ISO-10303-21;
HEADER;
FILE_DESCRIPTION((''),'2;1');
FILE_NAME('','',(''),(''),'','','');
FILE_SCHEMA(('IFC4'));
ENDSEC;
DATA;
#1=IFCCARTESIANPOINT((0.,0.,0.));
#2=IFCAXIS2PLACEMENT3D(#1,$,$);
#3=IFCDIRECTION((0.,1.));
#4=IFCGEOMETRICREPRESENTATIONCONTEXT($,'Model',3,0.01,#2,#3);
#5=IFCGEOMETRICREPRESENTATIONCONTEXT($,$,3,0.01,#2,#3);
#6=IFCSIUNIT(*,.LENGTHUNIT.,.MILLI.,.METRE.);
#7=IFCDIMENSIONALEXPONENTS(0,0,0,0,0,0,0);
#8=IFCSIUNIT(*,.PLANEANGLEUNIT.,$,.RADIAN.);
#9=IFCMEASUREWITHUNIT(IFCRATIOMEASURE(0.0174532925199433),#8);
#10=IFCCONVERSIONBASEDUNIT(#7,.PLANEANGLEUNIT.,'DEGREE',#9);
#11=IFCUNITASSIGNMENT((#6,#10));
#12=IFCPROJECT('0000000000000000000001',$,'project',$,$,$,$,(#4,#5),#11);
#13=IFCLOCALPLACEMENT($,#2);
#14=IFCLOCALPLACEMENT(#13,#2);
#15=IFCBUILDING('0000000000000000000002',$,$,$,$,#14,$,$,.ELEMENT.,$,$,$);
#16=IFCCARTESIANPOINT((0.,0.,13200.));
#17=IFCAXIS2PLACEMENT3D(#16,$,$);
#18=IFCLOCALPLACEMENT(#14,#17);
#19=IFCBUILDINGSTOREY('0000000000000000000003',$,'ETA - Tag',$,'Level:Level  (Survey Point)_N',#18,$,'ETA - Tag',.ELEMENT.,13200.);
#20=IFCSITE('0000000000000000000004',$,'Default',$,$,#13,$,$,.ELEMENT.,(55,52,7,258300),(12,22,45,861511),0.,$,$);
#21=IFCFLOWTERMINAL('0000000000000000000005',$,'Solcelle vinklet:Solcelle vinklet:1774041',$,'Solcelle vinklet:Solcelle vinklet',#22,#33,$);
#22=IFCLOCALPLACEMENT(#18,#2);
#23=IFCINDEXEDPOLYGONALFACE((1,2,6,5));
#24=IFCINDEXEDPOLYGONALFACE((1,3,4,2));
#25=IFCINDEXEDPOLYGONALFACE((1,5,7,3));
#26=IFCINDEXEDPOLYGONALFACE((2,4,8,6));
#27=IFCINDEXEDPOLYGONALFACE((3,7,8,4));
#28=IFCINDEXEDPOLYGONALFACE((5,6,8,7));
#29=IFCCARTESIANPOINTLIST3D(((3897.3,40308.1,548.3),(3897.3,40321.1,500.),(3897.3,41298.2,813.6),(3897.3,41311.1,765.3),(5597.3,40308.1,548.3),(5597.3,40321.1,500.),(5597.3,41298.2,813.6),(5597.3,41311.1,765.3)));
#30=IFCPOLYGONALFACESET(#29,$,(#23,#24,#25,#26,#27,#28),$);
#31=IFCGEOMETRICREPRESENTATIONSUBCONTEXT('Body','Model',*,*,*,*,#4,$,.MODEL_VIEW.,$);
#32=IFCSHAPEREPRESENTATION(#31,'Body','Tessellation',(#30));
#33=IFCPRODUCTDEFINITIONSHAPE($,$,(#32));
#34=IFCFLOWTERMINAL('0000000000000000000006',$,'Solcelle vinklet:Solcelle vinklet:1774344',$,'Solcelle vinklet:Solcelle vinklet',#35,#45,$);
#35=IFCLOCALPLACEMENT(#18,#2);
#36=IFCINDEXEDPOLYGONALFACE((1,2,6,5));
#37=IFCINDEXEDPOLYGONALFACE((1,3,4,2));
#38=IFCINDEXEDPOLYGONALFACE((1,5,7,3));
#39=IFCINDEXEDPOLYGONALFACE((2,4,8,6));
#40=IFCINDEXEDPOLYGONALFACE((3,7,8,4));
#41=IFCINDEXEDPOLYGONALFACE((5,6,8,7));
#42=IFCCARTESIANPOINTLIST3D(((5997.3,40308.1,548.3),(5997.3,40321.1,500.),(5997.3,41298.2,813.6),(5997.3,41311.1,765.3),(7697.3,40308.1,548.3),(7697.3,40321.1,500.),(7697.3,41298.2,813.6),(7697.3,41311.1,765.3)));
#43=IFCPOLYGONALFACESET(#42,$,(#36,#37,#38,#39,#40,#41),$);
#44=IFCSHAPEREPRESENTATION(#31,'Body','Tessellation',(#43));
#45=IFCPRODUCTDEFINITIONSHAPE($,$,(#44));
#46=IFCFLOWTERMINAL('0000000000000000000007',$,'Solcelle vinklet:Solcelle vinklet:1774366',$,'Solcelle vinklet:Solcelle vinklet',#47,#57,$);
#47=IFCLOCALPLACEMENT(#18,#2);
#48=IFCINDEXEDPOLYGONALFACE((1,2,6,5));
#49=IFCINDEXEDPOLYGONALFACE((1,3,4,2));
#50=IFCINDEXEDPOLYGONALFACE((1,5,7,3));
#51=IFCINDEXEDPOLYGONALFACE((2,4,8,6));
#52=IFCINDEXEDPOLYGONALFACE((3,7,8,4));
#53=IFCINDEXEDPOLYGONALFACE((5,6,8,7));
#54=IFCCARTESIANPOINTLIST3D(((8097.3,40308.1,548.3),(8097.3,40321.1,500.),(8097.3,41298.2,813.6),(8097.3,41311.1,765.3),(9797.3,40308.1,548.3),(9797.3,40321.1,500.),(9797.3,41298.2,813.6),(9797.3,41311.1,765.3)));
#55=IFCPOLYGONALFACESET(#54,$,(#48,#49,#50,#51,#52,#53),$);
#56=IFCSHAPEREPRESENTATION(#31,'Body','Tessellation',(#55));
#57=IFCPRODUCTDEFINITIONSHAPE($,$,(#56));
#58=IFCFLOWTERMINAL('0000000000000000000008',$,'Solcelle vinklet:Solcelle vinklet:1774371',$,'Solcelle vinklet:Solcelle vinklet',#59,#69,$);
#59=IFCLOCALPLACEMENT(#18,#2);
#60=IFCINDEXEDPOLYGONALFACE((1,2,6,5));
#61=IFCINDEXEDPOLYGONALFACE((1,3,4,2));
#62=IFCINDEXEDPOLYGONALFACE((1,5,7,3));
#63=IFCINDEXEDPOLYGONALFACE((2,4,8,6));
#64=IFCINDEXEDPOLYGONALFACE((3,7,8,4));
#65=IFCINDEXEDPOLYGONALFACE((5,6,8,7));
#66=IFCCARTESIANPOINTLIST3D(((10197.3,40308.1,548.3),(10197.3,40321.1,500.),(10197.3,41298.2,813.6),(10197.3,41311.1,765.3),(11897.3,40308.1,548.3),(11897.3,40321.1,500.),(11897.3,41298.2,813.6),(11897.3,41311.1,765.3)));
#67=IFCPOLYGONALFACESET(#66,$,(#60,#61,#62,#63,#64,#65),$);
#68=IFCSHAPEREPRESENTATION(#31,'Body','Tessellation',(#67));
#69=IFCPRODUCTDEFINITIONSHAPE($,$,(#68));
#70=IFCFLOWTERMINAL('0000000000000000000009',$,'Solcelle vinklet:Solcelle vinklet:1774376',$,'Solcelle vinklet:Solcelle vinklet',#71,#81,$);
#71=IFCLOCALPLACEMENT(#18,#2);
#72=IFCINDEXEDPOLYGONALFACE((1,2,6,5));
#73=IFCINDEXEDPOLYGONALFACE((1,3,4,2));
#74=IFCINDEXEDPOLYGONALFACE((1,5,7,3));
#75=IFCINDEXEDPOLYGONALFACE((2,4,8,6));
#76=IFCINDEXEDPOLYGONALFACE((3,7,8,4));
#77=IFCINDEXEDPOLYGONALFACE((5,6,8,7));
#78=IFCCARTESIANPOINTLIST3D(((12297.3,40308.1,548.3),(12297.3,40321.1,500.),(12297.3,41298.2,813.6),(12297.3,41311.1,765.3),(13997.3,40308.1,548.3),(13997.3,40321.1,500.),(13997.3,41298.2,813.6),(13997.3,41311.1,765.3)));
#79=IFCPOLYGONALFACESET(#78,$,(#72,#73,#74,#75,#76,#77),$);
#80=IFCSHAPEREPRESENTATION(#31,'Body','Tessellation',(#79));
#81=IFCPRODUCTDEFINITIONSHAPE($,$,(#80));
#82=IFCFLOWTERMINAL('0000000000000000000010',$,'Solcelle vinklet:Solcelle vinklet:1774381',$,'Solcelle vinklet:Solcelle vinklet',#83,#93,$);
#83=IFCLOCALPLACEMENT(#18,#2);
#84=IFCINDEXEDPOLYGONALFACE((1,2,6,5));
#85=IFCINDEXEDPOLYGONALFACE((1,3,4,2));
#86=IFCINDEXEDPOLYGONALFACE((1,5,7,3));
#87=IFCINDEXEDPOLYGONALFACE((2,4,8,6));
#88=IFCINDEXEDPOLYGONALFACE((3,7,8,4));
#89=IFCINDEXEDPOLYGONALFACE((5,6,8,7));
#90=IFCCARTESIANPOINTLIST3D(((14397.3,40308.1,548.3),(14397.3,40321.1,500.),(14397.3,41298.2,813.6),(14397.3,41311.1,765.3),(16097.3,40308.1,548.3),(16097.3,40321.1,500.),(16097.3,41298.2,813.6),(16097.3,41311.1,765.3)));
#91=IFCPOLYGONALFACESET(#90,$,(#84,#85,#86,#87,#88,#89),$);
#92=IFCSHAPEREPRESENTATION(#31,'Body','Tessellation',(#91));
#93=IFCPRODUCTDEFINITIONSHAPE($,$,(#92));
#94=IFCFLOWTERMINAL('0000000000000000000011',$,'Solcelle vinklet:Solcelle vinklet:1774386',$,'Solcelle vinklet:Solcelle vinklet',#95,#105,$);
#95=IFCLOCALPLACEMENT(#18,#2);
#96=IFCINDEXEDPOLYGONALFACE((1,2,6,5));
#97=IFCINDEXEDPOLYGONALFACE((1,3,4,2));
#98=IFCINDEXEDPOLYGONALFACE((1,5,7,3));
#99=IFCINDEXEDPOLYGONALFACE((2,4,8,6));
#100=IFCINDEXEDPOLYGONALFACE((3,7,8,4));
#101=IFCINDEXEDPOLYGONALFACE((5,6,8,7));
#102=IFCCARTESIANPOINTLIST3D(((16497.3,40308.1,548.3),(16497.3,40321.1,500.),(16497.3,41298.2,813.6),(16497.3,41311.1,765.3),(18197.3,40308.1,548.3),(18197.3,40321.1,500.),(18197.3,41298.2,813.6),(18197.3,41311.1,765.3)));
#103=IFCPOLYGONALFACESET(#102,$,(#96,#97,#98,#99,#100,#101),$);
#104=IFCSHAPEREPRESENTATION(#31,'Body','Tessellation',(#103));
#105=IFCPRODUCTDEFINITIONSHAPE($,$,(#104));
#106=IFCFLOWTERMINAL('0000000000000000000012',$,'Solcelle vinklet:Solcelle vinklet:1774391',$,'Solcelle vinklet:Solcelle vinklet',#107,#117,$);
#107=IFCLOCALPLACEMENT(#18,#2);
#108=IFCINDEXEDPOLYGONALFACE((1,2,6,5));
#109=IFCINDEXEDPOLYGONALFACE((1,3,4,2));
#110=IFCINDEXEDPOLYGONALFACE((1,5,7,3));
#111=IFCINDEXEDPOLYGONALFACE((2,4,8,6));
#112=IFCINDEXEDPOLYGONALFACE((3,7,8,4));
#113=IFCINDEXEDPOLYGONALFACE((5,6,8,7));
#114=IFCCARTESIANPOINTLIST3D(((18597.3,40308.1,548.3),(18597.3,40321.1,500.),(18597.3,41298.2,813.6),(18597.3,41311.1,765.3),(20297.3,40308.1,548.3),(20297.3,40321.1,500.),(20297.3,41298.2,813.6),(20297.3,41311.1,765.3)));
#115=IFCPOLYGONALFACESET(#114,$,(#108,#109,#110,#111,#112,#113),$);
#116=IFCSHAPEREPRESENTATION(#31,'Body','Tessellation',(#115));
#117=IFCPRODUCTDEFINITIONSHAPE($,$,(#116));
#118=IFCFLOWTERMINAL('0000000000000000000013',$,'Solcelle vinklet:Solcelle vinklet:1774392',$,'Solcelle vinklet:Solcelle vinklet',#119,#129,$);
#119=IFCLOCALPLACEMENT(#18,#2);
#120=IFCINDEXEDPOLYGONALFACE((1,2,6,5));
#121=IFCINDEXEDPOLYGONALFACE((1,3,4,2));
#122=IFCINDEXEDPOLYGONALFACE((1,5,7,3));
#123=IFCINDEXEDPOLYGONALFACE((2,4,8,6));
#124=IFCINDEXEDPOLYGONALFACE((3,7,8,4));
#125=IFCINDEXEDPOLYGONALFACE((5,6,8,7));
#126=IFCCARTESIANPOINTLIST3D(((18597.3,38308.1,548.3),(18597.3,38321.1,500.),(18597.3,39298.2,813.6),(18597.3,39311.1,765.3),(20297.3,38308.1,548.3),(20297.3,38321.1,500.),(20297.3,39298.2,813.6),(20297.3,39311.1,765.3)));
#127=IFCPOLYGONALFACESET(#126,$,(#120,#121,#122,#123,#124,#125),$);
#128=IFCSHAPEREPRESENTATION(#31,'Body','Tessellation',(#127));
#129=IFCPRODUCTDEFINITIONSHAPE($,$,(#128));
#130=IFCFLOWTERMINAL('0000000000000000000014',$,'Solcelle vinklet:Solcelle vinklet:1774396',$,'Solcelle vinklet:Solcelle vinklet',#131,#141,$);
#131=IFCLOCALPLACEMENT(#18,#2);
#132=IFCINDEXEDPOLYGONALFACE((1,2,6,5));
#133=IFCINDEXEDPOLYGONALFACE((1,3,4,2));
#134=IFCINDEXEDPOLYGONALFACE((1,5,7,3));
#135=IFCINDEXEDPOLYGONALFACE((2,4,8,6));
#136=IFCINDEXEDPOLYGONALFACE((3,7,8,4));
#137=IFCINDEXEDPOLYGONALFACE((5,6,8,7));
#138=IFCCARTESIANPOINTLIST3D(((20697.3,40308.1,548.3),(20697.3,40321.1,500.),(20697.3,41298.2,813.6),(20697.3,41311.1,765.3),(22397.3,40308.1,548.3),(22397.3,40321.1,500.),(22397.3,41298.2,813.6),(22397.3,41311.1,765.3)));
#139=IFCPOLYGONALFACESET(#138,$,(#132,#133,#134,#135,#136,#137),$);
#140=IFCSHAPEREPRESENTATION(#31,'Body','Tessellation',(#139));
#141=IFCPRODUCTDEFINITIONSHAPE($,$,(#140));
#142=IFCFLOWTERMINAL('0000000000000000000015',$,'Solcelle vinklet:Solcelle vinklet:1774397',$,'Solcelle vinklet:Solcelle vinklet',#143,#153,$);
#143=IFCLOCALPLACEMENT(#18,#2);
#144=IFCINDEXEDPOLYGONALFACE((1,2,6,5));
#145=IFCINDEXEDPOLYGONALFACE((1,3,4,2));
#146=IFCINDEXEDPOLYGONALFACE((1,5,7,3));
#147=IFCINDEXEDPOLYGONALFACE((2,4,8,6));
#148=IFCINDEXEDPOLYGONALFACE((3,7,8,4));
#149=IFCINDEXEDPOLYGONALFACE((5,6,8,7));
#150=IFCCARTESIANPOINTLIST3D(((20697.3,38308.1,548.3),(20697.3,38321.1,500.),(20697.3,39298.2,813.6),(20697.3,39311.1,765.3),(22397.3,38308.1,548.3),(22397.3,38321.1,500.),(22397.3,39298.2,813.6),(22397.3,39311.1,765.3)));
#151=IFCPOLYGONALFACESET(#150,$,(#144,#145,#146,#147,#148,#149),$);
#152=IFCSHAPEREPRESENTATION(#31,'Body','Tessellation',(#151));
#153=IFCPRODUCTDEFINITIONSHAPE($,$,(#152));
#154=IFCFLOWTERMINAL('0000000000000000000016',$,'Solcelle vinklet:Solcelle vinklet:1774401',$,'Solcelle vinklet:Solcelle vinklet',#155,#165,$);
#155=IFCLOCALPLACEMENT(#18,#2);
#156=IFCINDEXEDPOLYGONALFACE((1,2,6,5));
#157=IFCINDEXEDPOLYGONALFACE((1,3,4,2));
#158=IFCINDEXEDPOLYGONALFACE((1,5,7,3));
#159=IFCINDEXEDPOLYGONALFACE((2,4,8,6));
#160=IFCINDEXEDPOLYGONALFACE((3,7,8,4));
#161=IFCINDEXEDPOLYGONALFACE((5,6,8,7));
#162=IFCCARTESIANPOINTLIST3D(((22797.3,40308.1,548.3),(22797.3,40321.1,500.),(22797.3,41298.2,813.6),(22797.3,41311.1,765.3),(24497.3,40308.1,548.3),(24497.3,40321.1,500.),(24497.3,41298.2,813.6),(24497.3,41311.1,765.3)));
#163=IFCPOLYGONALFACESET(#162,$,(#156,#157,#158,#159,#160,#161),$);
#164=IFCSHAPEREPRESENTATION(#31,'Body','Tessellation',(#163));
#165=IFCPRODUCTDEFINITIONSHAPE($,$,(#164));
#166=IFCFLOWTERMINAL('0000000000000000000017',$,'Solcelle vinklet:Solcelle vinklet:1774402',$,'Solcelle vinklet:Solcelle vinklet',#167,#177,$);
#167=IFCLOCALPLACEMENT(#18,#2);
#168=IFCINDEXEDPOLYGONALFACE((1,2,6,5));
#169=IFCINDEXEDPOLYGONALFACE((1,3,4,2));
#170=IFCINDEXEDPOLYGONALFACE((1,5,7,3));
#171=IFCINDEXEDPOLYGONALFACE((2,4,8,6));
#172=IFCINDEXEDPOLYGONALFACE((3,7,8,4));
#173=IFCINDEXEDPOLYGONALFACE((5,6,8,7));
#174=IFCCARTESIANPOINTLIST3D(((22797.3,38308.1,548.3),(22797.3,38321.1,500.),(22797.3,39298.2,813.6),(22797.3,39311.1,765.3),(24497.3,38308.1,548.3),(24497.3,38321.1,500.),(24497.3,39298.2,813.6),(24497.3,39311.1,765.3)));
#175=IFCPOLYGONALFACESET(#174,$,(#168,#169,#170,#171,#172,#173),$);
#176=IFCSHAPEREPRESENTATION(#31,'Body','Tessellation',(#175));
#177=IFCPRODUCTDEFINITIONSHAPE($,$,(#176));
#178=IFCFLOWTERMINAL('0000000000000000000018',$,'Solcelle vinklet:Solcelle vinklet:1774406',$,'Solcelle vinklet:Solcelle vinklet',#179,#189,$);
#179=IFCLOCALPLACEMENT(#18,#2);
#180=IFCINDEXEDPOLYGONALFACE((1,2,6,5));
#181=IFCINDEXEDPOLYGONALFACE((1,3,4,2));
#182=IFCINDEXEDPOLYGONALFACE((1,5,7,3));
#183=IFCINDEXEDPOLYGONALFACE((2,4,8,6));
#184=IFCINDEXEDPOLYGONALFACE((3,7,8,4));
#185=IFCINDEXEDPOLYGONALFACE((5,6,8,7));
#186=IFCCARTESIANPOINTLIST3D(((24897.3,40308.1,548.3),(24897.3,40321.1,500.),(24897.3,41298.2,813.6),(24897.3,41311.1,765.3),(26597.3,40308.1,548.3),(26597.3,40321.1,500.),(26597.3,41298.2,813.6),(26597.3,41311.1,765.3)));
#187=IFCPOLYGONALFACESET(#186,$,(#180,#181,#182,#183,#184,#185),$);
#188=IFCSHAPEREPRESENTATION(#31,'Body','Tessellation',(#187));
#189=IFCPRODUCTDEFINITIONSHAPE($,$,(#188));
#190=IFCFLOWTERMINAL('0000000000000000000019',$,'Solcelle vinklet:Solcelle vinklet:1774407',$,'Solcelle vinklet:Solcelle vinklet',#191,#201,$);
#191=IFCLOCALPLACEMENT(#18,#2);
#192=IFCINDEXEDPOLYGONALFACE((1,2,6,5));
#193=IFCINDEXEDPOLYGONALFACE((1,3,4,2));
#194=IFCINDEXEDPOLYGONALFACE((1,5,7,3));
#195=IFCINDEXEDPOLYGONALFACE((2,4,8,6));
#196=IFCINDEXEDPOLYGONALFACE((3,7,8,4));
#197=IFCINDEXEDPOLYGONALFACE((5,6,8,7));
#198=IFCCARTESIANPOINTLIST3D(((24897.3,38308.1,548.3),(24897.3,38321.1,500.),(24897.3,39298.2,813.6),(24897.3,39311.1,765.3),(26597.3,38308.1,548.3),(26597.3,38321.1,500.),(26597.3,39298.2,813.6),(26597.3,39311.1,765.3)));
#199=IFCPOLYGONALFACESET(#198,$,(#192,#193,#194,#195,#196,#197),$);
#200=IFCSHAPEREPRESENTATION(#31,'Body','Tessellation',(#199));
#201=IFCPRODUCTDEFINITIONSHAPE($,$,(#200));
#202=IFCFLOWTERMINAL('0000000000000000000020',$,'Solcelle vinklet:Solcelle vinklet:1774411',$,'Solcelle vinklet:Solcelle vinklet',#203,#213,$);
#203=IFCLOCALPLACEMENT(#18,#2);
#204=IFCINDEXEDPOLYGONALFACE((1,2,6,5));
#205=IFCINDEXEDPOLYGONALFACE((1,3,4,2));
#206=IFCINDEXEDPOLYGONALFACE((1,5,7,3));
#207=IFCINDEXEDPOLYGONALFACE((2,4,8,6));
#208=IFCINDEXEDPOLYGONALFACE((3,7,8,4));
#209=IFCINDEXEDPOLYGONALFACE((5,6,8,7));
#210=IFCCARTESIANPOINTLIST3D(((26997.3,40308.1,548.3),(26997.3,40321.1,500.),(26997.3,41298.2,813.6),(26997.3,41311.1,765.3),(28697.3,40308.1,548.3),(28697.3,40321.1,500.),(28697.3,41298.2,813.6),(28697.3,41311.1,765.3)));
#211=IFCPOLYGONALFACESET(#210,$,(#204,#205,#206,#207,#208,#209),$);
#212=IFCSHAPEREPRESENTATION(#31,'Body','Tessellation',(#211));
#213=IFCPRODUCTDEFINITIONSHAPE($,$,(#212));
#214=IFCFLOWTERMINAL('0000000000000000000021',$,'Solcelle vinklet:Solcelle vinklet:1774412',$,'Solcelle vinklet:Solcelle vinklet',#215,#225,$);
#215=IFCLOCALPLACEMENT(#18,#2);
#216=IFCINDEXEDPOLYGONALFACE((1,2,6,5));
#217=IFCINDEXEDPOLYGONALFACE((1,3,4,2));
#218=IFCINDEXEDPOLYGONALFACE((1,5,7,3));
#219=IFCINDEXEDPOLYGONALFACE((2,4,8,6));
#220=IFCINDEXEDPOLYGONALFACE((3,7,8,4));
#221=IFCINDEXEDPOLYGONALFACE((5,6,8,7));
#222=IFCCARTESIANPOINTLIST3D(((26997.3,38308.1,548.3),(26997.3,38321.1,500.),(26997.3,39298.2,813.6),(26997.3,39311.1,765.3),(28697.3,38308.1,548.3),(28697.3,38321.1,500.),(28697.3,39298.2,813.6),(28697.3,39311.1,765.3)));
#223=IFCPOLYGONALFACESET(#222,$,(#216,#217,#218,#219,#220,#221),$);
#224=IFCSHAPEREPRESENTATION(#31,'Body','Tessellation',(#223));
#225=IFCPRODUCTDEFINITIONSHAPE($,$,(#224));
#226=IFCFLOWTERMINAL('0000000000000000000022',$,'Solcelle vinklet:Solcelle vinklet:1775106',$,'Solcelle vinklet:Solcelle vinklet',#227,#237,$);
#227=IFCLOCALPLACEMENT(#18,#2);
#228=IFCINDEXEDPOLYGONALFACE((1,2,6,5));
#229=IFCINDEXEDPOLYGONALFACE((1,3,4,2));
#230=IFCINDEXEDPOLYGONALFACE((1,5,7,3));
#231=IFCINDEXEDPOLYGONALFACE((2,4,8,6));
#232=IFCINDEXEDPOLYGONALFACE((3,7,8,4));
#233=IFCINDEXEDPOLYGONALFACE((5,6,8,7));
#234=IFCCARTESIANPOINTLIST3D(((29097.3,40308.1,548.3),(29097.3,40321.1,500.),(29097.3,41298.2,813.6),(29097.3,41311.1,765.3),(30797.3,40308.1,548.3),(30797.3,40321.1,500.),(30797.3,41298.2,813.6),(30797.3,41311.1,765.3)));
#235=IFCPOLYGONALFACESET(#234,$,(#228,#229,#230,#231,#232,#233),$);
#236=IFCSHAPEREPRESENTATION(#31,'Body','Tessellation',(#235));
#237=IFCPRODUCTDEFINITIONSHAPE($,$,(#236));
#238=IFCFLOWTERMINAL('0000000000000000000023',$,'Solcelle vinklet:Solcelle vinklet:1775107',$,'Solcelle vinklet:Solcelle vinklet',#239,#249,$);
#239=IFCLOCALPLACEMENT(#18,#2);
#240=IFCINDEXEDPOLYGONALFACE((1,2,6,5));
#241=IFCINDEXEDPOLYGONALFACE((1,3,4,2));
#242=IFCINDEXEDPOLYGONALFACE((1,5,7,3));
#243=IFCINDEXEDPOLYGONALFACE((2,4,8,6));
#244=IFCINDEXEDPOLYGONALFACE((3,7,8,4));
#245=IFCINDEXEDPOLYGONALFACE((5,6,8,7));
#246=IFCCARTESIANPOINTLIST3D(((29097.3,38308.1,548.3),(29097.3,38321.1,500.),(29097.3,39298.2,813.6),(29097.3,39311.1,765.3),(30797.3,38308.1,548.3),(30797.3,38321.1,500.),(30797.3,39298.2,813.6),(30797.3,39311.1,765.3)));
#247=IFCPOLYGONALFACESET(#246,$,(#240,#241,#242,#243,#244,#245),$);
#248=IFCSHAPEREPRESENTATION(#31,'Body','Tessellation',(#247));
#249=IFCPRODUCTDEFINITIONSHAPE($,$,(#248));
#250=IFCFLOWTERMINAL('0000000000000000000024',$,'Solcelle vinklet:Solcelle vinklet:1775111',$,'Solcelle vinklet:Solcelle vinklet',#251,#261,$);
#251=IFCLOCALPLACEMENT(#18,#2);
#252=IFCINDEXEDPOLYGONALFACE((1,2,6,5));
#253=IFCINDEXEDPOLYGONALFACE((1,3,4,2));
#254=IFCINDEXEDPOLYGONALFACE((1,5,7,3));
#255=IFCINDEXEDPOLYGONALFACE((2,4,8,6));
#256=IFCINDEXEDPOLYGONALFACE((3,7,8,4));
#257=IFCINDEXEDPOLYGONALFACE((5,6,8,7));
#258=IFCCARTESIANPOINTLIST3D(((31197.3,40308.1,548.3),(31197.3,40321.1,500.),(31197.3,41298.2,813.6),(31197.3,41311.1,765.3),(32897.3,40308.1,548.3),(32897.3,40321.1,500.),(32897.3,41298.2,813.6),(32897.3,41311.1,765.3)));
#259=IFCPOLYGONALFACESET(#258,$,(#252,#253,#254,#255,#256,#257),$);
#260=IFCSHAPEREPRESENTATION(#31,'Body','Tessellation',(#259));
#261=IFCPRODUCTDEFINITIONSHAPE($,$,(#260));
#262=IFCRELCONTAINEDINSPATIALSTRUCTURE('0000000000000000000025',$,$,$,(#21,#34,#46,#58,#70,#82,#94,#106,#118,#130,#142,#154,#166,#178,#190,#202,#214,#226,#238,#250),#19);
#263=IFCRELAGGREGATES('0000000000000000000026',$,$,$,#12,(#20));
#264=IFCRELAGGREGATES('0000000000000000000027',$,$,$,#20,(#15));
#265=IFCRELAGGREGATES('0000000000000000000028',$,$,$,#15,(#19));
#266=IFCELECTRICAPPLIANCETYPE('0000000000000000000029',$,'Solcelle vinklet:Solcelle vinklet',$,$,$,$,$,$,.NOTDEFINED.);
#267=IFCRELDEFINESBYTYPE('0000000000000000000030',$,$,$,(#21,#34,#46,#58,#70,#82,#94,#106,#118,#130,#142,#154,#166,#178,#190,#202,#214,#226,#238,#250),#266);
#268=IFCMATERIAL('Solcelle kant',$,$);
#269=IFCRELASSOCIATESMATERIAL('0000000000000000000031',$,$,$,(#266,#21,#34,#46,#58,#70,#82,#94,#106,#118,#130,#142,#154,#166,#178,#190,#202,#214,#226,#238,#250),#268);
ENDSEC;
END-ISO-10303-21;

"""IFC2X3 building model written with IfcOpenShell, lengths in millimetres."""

from ifc_helpers import new_model, entity, si_unit, converted_unit, direction, frame, frame_2d, origin, place, context, subcontext, project, spatial, rectangle, extrude, source, transform, mapped, material, type_object, type_shapes, element, save


model = new_model("IFC2X3")

# Units and contexts
model_context = context("Model", 3, precision=0.01, world=origin(), true_north=direction((0.0, 1.0)))
context_of_model = context(None, 3, precision=0.01, world=origin(), true_north=direction((0.0, 1.0)))
body_context = subcontext(model_context, "Body", "Model", "MODEL_VIEW")
ifc_project = project(units=[si_unit("LENGTHUNIT", "METRE", prefix="MILLI"), converted_unit("PLANEANGLEUNIT", "DEGREE", entity("IfcRatioMeasure", 0.0174532925199433), si_unit("PLANEANGLEUNIT", "RADIAN"), dimensions=[0, 0, 0, 0, 0, 0, 0])], contexts=[model_context, context_of_model])

# Site, building, storey
site_placement = place(None, origin())
site = spatial("IfcSite", under=ifc_project, at=site_placement, Name="Default", CompositionType="ELEMENT", RefLatitude=(55, 52, 7, 258300), RefLongitude=(12, 22, 45, 861511), RefElevation=0.0)
building_placement = place(site_placement, origin())
building = spatial("IfcBuilding", under=site, at=building_placement, CompositionType="ELEMENT")
storey_placement = place(building_placement, frame((0.0, 0.0, 13200.0)))
storey = spatial("IfcBuildingStorey", under=building, at=storey_placement, Name="ETA - Tag", ObjectType="Level:Level  (Survey Point)_N", LongName="ETA - Tag", CompositionType="ELEMENT", Elevation=13200.0)

# Flow terminals
ifc_material = material(Name="Solcelle kant")
electric_appliance_type = type_object("IfcElectricApplianceType", Name="Solcelle vinklet:Solcelle vinklet", PredefinedType="NOTDEFINED", material=ifc_material)
shared_shape = source(origin(), body_context, "Body", "SweptSolid", [
    extrude(rectangle(XDim=50.0, YDim=1025.0, at=frame_2d((0.0, 0.0), x_axis=(1.0, 0.0))), frame((-850.0, 488.6, 156.8), z_axis=(1.0, 0.0, 0.0), x_axis=(0.0, 0.258819, -0.965926)), (0.0, 0.0, 1.0), 1700.0),
])
type_shapes(electric_appliance_type, [shared_shape])
for number, where, name in (
    (1, (4747.3, 40321.1, 500.0), "Solcelle vinklet:Solcelle vinklet:1774041"),
    (2, (6847.3, 40321.1, 500.0), "Solcelle vinklet:Solcelle vinklet:1774344"),
    (3, (8947.3, 40321.1, 500.0), "Solcelle vinklet:Solcelle vinklet:1774366"),
    (4, (11047.3, 40321.1, 500.0), "Solcelle vinklet:Solcelle vinklet:1774371"),
    (5, (13147.3, 40321.1, 500.0), "Solcelle vinklet:Solcelle vinklet:1774376"),
    (6, (15247.3, 40321.1, 500.0), "Solcelle vinklet:Solcelle vinklet:1774381"),
    (7, (17347.3, 40321.1, 500.0), "Solcelle vinklet:Solcelle vinklet:1774386"),
    (8, (19447.3, 40321.1, 500.0), "Solcelle vinklet:Solcelle vinklet:1774391"),
    (9, (19447.3, 38321.1, 500.0), "Solcelle vinklet:Solcelle vinklet:1774392"),
    (10, (21547.3, 40321.1, 500.0), "Solcelle vinklet:Solcelle vinklet:1774396"),
    (11, (21547.3, 38321.1, 500.0), "Solcelle vinklet:Solcelle vinklet:1774397"),
    (12, (23647.3, 40321.1, 500.0), "Solcelle vinklet:Solcelle vinklet:1774401"),
    (13, (23647.3, 38321.1, 500.0), "Solcelle vinklet:Solcelle vinklet:1774402"),
    (14, (25747.3, 40321.1, 500.0), "Solcelle vinklet:Solcelle vinklet:1774406"),
    (15, (25747.3, 38321.1, 500.0), "Solcelle vinklet:Solcelle vinklet:1774407"),
    (16, (27847.3, 40321.1, 500.0), "Solcelle vinklet:Solcelle vinklet:1774411"),
    (17, (27847.3, 38321.1, 500.0), "Solcelle vinklet:Solcelle vinklet:1774412"),
    (18, (29947.3, 40321.1, 500.0), "Solcelle vinklet:Solcelle vinklet:1775106"),
    (19, (29947.3, 38321.1, 500.0), "Solcelle vinklet:Solcelle vinklet:1775107"),
    (20, (32047.3, 40321.1, 500.0), "Solcelle vinklet:Solcelle vinklet:1775111"),
):
    element("IfcFlowTerminal", number, at=place(storey_placement, frame(where)), inside=storey, type_object=electric_appliance_type, material=ifc_material, Name=name, ObjectType="Solcelle vinklet:Solcelle vinklet", context=body_context, shape_type="MappedRepresentation", body=[
        mapped(shared_shape, transform((0.0, 0.0, 0.0), scale=1.0)),
    ])

save(model, "model.ifc")
